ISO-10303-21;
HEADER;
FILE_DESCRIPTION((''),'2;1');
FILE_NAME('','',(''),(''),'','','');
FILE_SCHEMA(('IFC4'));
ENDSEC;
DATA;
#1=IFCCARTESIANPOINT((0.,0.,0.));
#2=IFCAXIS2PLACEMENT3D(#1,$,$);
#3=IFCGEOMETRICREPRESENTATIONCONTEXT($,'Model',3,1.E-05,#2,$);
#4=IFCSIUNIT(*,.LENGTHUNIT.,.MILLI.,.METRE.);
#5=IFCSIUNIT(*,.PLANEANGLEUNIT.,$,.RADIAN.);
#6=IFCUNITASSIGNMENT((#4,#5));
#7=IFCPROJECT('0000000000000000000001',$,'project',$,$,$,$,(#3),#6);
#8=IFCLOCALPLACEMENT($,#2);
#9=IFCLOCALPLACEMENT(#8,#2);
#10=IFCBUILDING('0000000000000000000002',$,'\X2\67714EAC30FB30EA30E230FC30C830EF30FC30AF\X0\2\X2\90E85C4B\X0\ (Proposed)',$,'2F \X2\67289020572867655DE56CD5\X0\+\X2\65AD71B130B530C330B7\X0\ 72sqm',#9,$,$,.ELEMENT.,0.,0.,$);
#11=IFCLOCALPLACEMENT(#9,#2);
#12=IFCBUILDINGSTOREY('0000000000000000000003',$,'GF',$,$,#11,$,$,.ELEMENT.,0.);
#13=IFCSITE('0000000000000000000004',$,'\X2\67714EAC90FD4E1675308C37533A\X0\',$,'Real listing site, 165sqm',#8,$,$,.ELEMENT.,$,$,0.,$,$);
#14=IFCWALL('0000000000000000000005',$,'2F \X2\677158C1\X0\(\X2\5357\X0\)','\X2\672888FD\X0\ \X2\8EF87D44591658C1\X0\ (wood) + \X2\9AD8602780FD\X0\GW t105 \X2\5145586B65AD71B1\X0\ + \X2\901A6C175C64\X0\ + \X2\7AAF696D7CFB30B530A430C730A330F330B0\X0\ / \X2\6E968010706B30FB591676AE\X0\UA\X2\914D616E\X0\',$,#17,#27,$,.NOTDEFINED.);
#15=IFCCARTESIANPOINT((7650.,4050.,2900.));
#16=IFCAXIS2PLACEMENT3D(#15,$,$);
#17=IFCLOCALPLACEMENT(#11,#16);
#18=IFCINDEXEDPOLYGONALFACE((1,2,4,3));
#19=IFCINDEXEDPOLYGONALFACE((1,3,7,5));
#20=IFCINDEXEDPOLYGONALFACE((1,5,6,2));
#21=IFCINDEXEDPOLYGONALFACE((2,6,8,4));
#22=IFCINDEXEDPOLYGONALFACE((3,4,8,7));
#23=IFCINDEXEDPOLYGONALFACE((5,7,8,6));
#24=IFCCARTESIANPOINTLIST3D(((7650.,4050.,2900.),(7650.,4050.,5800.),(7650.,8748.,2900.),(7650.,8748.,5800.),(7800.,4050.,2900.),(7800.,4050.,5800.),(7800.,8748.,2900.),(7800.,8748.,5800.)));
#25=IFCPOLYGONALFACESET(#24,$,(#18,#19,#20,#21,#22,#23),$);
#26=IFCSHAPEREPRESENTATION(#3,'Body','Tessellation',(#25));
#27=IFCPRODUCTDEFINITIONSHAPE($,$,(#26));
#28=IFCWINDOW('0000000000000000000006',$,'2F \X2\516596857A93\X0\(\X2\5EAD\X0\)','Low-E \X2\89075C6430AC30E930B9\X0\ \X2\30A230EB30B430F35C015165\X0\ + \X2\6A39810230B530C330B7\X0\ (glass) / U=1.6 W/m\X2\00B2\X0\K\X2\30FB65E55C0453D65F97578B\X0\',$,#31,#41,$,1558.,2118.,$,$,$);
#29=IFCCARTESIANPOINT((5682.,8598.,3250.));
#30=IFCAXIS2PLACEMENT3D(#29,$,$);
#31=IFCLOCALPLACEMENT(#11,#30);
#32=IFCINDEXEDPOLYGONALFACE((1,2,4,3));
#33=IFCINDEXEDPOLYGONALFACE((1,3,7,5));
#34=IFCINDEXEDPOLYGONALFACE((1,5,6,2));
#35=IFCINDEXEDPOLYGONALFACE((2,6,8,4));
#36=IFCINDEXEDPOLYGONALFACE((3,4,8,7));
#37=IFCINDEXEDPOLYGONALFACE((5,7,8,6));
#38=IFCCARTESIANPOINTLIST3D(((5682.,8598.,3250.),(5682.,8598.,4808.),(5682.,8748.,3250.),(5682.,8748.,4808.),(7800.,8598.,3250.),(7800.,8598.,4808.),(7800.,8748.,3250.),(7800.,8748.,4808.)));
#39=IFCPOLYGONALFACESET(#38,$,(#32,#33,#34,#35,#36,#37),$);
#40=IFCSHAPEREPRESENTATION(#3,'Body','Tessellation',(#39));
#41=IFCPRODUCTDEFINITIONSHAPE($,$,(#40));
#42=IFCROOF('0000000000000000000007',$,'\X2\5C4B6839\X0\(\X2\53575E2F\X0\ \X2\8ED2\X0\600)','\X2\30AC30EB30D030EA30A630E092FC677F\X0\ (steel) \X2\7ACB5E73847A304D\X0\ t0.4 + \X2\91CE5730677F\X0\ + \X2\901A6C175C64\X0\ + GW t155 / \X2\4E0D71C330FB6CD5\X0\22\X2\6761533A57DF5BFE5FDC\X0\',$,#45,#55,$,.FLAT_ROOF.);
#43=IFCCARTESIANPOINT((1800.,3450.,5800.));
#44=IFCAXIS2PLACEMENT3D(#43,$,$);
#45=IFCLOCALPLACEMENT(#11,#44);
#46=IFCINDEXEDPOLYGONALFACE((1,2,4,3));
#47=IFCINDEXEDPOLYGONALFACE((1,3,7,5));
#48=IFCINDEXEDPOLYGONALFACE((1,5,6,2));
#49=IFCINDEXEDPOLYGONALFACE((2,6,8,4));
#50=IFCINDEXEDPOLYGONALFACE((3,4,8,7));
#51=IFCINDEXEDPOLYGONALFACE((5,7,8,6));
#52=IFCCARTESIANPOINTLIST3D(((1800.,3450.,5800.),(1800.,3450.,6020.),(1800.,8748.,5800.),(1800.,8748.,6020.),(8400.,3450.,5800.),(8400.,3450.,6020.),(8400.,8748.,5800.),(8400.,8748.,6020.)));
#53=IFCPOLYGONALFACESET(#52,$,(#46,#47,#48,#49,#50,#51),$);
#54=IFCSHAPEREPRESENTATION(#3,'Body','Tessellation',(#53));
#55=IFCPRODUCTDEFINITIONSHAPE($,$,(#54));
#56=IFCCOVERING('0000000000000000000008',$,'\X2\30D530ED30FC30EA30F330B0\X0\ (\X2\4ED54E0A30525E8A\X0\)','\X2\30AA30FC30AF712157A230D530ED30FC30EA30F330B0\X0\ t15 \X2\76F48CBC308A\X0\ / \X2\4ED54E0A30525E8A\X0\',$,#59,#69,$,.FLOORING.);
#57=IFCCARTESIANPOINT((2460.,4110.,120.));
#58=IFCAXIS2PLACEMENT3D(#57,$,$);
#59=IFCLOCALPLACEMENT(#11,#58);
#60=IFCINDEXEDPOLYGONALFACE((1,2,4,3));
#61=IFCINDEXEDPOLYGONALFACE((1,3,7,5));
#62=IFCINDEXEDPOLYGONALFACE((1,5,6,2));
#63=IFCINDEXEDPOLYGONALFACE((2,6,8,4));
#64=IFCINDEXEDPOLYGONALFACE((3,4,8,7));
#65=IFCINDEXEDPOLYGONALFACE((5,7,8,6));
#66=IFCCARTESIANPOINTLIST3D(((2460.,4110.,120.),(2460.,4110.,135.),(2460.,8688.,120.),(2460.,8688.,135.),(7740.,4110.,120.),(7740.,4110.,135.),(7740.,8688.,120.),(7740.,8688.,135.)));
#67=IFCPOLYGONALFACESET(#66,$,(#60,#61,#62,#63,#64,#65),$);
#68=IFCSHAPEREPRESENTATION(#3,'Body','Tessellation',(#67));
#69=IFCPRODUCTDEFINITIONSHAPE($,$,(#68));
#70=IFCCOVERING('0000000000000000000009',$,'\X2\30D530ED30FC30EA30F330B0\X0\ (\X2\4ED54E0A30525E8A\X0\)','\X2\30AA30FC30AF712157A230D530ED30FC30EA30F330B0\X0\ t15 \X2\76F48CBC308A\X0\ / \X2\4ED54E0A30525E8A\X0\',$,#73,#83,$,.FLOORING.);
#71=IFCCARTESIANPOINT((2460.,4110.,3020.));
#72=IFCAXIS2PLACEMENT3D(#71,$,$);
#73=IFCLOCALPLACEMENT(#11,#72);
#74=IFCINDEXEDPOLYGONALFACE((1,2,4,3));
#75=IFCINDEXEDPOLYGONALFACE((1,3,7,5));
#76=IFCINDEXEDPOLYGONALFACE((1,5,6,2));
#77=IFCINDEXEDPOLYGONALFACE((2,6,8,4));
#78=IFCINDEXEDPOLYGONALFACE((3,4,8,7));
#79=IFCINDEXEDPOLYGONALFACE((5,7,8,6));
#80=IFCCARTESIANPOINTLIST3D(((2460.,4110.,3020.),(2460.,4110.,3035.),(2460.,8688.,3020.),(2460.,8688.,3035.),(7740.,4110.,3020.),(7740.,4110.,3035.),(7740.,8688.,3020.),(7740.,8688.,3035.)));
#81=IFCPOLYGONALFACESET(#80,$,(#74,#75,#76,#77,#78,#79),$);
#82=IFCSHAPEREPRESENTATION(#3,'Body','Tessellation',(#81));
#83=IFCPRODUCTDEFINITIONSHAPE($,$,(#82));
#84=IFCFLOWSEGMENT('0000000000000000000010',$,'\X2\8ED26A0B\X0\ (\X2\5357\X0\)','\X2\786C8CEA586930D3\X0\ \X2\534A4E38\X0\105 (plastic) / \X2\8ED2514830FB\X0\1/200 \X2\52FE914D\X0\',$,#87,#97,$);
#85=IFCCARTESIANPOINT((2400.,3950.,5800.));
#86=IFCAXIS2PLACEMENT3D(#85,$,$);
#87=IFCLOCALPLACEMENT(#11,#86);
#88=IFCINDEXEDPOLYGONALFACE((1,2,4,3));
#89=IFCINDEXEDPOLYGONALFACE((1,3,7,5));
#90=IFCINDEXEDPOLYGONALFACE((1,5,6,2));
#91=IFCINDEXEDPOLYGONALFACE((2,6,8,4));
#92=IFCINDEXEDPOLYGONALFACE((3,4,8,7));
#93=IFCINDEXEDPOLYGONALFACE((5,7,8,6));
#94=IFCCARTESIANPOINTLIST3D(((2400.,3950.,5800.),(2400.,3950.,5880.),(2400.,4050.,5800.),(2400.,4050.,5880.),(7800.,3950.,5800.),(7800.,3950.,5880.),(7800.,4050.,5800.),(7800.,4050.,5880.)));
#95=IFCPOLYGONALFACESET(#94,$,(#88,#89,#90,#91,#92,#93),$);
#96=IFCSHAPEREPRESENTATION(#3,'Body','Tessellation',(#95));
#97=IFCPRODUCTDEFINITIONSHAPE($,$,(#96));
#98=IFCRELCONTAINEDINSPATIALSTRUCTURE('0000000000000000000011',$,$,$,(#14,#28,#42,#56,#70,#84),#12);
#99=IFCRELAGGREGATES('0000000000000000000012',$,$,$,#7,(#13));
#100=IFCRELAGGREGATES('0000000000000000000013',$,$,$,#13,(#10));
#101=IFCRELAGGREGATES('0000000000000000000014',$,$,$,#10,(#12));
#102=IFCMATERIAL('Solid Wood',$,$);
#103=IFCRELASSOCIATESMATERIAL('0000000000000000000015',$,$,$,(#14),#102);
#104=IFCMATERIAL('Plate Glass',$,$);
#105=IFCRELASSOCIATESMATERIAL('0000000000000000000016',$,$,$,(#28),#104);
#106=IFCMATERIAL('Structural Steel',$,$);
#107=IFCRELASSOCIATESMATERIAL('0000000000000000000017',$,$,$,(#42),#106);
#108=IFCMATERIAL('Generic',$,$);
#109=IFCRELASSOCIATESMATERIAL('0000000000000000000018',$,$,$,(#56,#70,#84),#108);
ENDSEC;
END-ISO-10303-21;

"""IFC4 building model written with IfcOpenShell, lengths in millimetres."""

from ifc_helpers import new_model, si_unit, frame, frame_2d, origin, place, context, project, spatial, rectangle, extrude, material, element, fill, save


model = new_model("IFC4")

# Units and contexts
model_context = context("Model", 3, precision=1e-05, world=origin())
ifc_project = project(units=[si_unit("LENGTHUNIT", "METRE", prefix="MILLI"), si_unit("PLANEANGLEUNIT", "RADIAN")], contexts=[model_context])

# Site, building, storey
site_placement = place(None, origin())
site = spatial("IfcSite", under=ifc_project, at=site_placement, Name="東京都世田谷区", ObjectType="Real listing site, 165sqm", CompositionType="ELEMENT", RefElevation=0.0)
building_placement = place(site_placement, origin())
building = spatial("IfcBuilding", under=site, at=building_placement, Name="東京・リモートワーク2部屋 (Proposed)", ObjectType="2F 木造在来工法+断熱サッシ 72sqm", CompositionType="ELEMENT", ElevationOfRefHeight=0.0, ElevationOfTerrain=0.0)
storey_placement = place(building_placement, origin())
storey = spatial("IfcBuildingStorey", under=building, at=storey_placement, Name="GF", CompositionType="ELEMENT", Elevation=0.0)

# Shared definitions
ifc_material_1 = material(Name="Solid Wood")

# Shared definitions
ifc_material_2 = material(Name="Plate Glass")

# Wall, opening, window
wall_1_placement = place(storey_placement, frame((7650.0, 4050.0, 2900.0)))
wall_1 = element("IfcWall", 1, at=wall_1_placement, inside=storey, material=ifc_material_1, Name="2F 東壁(南)", Description="木製 軸組外壁 (wood) + 高性能GW t105 充填断熱 + 通気層 + 窯業系サイディング / 準耐火・外皮UA配慮", PredefinedType="NOTDEFINED", context=model_context, shape_type="SweptSolid", body=[
    extrude(rectangle(XDim=150.0, YDim=4698.0, at=frame_2d((75.0, 2349.0))), frame((7650.0, 4050.0, 2900.0)), (0.0, 0.0, 1.0), 2900.0),
])
opening_1_placement = place(storey_placement, frame((5682.0, 8598.0, 3250.0)))
opening_1 = element("IfcOpeningElement", 2, at=opening_1_placement, cuts=wall_1, PredefinedType="NOTDEFINED", context=model_context, shape_type="SweptSolid", body=[
    extrude(rectangle(XDim=2118.0, YDim=150.0, at=frame_2d((1059.0, 75.0))), frame((5682.0, 8598.0, 3250.0)), (0.0, 0.0, 1.0), 1558.0),
])
window_1_placement = place(storey_placement, frame((5682.0, 8598.0, 3250.0)))
window_1 = element("IfcWindow", 3, at=window_1_placement, inside=storey, material=ifc_material_2, Name="2F 入隅窓(庭)", Description="Low-E 複層ガラス アルゴン封入 + 樹脂サッシ (glass) / U=1.6 W/m²K・日射取得型", OverallHeight=1558.0, OverallWidth=2118.0, context=model_context, shape_type="SweptSolid", body=[
    extrude(rectangle(XDim=2118.0, YDim=150.0, at=frame_2d((1059.0, 75.0))), frame((5682.0, 8598.0, 3250.0)), (0.0, 0.0, 1.0), 1558.0),
])
fill(opening_1, window_1)

# Roof
ifc_material_3 = material(Name="Structural Steel")
for number, where, name in (
    (4, (1800.0, 3450.0, 5800.0), "屋根(南帯 軒600)"),
):
    element("IfcRoof", number, at=place(storey_placement, frame(where)), inside=storey, material=ifc_material_3, Name=name, Description="ガルバリウム鋼板 (steel) 立平葺き t0.4 + 野地板 + 通気層 + GW t155 / 不燃・法22条区域対応", PredefinedType="FLAT_ROOF", context=model_context, shape_type="SweptSolid", body=[
        extrude(rectangle(XDim=6600.0, YDim=5298.0, at=frame_2d((3300.0, 2649.0))), frame((1800.0, 3450.0, 5800.0)), (0.0, 0.0, 1.0), 220.0),
    ])

# Coverings
ifc_material_4 = material(Name="Generic")
covering_1_placement = place(storey_placement, frame((2460.0, 4110.0, 120.0)))
element("IfcCovering", 5, at=covering_1_placement, inside=storey, material=ifc_material_4, Name="フローリング (仕上げ床)", Description="オーク無垢フローリング t15 直貼り / 仕上げ床", PredefinedType="FLOORING", context=model_context, shape_type="SweptSolid", body=[
    extrude(rectangle(XDim=5280.0, YDim=4578.0, at=frame_2d((2640.0, 2289.0))), frame((2460.0, 4110.0, 120.0)), (0.0, 0.0, 1.0), 15.0),
])
covering_2_placement = place(storey_placement, frame((2460.0, 4110.0, 3020.0)))
element("IfcCovering", 6, at=covering_2_placement, inside=storey, material=ifc_material_4, Name="フローリング (仕上げ床)", Description="オーク無垢フローリング t15 直貼り / 仕上げ床", PredefinedType="FLOORING", context=model_context, shape_type="SweptSolid", body=[
    extrude(rectangle(XDim=5280.0, YDim=4578.0, at=frame_2d((2640.0, 2289.0))), frame((2460.0, 4110.0, 3020.0)), (0.0, 0.0, 1.0), 15.0),
])

# Flow segment
flow_segment_placement = place(storey_placement, frame((2400.0, 3950.0, 5800.0)))
element("IfcFlowSegment", 7, at=flow_segment_placement, inside=storey, material=ifc_material_4, Name="軒樋 (南)", Description="硬質塩ビ 半丸105 (plastic) / 軒先・1/200 勾配", context=model_context, shape_type="SweptSolid", body=[
    extrude(rectangle(XDim=5400.0, YDim=100.0, at=frame_2d((2700.0, 50.0))), frame((2400.0, 3950.0, 5800.0)), (0.0, 0.0, 1.0), 80.0),
])

save(model, "model.ifc")
